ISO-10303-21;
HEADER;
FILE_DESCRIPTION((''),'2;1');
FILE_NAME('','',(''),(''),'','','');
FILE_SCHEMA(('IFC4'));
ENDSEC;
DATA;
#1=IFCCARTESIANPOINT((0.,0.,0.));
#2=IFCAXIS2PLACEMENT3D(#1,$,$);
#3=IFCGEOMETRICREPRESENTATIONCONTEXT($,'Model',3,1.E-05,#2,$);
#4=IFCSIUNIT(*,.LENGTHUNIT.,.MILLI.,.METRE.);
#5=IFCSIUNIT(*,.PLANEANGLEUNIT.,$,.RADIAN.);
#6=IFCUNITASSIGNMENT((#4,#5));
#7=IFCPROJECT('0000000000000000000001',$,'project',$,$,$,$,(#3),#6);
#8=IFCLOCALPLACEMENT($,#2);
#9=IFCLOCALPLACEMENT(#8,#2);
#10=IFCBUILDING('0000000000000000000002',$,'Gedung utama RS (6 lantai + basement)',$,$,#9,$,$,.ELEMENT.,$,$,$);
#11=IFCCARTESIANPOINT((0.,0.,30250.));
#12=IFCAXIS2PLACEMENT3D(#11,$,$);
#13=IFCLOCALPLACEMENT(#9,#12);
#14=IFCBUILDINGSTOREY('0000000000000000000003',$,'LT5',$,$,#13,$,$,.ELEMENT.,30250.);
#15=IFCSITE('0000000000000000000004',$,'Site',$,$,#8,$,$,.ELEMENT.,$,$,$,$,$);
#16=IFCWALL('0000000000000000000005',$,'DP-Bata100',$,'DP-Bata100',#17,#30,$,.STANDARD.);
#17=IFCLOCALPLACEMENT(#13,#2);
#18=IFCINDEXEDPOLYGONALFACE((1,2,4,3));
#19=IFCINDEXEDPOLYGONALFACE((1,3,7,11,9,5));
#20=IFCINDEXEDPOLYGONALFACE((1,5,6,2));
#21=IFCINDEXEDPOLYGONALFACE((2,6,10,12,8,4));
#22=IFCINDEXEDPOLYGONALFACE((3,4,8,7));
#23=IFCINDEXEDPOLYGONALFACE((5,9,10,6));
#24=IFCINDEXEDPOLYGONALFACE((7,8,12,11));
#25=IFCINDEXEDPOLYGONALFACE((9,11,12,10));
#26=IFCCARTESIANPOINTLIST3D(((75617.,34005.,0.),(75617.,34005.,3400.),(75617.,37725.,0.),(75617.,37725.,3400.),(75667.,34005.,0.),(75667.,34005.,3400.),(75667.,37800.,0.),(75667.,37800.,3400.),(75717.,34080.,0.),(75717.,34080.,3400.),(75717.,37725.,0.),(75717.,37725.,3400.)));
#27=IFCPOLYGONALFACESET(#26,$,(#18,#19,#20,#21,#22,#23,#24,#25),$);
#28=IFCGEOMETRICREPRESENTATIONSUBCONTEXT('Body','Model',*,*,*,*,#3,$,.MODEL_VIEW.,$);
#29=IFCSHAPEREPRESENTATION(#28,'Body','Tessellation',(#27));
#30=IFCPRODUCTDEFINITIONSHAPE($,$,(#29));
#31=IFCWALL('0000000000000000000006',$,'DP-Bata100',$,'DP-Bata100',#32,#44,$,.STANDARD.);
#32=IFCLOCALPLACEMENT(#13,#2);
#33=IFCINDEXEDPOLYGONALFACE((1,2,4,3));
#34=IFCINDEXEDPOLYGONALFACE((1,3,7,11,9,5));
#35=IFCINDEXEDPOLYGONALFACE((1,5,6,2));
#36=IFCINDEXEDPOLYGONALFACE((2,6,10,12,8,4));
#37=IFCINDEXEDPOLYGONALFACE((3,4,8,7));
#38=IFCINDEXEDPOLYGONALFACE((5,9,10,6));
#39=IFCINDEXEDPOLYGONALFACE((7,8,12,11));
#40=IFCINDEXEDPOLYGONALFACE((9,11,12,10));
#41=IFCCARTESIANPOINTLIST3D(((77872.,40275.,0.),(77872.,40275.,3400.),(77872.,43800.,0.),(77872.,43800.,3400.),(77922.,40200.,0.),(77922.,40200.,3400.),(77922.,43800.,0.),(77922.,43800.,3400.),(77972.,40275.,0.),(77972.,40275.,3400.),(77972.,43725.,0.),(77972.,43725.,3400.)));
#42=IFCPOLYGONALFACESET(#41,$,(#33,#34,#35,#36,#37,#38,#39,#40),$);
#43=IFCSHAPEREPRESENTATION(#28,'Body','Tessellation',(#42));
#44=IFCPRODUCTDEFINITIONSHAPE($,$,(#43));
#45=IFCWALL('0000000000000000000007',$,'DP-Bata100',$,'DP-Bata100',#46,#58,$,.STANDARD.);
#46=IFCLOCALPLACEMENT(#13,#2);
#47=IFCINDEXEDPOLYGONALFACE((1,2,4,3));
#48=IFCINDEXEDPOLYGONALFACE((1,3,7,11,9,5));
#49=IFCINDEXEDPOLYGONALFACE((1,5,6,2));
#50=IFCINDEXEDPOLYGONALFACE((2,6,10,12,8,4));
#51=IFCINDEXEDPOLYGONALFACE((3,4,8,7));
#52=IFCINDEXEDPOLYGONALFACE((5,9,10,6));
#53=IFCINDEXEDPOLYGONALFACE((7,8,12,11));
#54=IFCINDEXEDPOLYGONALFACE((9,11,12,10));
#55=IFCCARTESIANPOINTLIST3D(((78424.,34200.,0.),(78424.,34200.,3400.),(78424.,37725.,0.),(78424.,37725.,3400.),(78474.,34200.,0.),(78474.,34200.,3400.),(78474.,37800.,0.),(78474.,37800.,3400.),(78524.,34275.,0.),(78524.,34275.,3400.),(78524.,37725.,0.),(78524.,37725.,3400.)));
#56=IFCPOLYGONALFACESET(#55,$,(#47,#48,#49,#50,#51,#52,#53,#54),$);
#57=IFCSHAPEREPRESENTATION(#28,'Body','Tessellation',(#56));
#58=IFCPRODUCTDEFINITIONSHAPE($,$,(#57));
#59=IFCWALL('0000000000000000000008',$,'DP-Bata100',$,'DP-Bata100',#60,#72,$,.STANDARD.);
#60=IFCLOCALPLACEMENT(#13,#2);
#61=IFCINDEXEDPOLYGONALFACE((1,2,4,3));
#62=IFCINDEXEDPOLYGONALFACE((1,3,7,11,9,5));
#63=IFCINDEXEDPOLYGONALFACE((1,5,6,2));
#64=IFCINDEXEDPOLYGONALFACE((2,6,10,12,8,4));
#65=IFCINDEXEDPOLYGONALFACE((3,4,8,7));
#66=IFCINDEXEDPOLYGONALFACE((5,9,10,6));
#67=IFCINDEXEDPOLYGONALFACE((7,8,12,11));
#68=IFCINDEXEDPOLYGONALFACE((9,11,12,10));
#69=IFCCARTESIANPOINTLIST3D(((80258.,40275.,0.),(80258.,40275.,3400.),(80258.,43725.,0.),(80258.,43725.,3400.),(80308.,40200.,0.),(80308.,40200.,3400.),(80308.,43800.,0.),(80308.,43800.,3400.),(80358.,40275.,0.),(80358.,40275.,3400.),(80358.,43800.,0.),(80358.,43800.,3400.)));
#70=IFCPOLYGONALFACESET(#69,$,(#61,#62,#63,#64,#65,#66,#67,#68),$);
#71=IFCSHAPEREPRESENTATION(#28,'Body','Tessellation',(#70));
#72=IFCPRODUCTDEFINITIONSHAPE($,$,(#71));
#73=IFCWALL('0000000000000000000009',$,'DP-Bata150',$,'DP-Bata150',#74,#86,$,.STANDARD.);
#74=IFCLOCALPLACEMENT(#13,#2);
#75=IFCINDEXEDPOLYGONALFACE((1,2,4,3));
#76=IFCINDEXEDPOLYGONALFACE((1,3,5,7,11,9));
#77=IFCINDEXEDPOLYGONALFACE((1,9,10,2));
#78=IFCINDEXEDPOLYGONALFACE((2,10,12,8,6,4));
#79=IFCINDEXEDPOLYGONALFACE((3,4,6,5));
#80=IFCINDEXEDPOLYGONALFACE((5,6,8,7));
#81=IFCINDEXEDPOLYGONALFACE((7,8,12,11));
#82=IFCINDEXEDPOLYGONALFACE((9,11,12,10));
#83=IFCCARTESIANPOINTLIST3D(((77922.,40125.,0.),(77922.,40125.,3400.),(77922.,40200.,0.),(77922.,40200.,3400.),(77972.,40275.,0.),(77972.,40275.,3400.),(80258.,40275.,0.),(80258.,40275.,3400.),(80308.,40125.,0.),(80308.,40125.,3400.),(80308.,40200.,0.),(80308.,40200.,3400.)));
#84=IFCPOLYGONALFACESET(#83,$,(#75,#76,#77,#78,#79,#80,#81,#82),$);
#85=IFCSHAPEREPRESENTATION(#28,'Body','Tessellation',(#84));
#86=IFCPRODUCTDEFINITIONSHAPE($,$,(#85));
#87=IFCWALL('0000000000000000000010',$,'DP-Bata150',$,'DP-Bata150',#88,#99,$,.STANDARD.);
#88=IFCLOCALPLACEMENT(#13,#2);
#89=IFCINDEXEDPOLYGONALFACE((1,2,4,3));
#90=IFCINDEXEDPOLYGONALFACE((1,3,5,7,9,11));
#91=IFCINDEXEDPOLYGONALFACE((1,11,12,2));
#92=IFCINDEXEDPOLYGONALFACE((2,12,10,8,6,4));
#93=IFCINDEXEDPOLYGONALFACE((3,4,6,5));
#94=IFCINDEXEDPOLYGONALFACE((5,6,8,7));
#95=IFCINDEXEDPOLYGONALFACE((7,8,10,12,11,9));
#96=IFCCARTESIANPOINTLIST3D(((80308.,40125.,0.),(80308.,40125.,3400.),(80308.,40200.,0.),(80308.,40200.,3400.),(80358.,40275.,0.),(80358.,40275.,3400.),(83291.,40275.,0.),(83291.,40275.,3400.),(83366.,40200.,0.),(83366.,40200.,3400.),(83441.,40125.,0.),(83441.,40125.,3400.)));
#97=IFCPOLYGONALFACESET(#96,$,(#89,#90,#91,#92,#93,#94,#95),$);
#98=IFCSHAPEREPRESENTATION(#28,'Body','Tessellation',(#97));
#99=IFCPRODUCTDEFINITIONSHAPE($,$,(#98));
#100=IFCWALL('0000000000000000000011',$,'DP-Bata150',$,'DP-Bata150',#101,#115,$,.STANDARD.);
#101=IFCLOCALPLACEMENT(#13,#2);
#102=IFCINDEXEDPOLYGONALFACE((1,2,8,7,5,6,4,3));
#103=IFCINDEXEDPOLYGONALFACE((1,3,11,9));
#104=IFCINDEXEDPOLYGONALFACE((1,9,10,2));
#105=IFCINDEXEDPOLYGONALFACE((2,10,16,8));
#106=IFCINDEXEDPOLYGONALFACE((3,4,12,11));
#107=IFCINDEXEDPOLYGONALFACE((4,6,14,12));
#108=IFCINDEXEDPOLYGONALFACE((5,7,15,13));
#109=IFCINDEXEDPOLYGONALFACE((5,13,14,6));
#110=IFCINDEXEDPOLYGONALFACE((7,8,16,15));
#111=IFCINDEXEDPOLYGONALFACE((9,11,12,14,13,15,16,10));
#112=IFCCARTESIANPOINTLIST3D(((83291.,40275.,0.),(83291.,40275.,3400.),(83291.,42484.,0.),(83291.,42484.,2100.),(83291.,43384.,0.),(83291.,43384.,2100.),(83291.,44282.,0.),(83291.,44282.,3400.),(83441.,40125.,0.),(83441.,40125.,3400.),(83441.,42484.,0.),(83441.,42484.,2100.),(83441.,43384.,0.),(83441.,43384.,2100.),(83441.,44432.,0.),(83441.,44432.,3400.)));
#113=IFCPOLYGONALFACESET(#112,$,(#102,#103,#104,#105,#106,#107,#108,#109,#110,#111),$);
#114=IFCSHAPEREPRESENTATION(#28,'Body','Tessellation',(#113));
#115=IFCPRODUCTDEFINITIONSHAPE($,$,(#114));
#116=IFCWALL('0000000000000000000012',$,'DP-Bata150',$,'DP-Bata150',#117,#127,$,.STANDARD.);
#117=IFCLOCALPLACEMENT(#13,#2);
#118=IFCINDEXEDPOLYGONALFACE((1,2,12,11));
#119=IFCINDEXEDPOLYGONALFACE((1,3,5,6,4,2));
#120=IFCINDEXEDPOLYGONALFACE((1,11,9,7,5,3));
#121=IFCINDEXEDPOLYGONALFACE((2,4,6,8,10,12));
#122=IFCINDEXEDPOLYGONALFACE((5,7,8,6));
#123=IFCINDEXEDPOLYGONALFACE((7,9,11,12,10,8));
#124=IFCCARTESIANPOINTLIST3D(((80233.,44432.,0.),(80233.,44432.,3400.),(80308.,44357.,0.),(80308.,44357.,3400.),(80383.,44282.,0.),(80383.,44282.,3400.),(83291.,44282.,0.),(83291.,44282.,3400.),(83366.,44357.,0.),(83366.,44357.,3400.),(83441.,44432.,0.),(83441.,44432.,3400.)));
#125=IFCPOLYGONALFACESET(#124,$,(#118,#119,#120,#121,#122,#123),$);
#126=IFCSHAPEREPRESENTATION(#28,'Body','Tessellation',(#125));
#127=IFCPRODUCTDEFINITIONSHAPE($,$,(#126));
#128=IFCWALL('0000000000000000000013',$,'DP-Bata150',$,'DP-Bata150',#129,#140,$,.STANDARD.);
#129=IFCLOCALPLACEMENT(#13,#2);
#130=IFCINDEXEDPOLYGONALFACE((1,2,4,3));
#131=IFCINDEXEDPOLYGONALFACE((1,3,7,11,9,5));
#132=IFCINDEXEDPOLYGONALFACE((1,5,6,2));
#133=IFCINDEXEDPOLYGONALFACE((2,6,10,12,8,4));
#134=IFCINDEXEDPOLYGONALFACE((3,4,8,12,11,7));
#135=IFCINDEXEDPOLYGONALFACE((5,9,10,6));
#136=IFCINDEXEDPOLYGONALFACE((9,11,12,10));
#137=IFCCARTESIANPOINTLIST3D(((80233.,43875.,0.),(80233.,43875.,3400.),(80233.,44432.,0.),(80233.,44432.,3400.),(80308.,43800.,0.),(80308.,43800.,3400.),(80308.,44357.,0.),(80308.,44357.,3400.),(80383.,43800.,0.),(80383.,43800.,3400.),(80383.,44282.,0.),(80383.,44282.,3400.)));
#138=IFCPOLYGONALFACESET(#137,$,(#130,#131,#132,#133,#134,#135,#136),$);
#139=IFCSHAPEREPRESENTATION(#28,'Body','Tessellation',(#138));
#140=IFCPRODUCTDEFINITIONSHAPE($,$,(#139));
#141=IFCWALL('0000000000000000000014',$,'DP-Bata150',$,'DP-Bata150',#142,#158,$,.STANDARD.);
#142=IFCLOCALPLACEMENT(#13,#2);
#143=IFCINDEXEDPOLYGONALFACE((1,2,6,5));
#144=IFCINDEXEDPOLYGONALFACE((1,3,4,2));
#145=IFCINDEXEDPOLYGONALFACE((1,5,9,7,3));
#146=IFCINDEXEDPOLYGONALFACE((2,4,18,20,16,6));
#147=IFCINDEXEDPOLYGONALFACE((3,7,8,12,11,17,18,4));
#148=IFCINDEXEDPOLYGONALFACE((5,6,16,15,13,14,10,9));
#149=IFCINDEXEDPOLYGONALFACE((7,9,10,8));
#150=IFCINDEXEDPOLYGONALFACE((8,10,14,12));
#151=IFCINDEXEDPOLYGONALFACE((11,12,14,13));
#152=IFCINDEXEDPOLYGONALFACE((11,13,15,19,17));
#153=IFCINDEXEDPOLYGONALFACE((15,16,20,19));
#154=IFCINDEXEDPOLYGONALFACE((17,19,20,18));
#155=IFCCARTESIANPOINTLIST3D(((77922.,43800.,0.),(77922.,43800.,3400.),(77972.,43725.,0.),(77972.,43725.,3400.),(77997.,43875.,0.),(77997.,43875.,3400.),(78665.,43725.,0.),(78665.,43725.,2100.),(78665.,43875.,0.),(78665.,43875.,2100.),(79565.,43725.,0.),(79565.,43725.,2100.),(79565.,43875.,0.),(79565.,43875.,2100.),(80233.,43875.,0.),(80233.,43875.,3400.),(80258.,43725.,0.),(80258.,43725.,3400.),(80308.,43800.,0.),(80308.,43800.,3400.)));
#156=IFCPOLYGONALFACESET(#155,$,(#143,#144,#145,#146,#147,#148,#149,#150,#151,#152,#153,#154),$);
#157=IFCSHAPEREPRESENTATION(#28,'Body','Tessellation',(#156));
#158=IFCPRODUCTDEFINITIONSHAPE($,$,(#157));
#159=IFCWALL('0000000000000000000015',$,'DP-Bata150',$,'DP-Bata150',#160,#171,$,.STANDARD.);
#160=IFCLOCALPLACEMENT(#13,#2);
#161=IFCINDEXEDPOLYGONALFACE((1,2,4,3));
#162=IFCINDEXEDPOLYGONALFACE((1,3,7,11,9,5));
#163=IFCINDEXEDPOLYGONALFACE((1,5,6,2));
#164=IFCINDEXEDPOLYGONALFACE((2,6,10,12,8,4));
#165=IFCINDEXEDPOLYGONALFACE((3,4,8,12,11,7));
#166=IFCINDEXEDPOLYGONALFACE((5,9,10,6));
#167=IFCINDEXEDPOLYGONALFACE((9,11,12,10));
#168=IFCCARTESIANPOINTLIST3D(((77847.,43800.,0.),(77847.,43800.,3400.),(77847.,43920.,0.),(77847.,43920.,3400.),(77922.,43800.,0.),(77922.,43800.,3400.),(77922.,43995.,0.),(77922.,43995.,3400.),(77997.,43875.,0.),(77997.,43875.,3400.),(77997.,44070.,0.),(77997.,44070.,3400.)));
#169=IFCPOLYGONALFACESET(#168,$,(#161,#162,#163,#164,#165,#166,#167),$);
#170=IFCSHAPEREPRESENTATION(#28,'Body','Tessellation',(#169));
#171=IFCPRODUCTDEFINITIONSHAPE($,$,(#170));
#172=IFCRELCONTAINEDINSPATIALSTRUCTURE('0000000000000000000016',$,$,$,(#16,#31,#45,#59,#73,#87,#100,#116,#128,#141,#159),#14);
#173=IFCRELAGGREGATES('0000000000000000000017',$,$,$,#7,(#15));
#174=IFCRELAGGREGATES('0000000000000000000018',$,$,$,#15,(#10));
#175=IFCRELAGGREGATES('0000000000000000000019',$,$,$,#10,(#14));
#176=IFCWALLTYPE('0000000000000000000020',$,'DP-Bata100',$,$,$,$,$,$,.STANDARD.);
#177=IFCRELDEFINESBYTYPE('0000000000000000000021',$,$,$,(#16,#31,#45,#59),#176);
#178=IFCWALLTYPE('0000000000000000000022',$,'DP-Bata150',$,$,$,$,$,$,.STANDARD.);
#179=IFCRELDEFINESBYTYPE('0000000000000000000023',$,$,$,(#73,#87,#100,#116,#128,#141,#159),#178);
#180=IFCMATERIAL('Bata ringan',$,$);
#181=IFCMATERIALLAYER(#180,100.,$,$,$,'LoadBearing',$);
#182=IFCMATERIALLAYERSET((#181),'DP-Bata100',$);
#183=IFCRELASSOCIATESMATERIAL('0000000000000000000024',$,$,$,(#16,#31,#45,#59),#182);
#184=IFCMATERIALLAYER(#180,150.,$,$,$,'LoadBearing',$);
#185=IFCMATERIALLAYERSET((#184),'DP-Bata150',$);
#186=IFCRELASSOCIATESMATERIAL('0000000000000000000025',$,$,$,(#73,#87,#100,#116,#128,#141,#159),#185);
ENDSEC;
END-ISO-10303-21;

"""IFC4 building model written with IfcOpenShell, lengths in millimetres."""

from ifc_helpers import new_model, si_unit, frame, frame_2d, origin, place, context, subcontext, project, spatial, polyline, rectangle, outline, extrude, material, layer, layer_set, layer_usage, type_object, element, save


model = new_model("IFC4")

# Units and contexts
model_context = context("Model", 3, precision=1e-05, world=origin())
body_context = subcontext(model_context, "Body", "Model", "MODEL_VIEW")
ifc_project = project(units=[si_unit("LENGTHUNIT", "METRE", prefix="MILLI"), si_unit("PLANEANGLEUNIT", "RADIAN")], contexts=[model_context])

# Site, building, storey
site_placement = place(None, origin())
site = spatial("IfcSite", under=ifc_project, at=site_placement, Name="Site", CompositionType="ELEMENT")
building_placement = place(site_placement, origin())
building = spatial("IfcBuilding", under=site, at=building_placement, Name="Gedung utama RS (6 lantai + basement)", CompositionType="ELEMENT")
storey_placement = place(building_placement, frame((0.0, 0.0, 30250.0)))
storey = spatial("IfcBuildingStorey", under=building, at=storey_placement, Name="LT5", CompositionType="ELEMENT", Elevation=30250.0)

# Walls
ifc_material_1 = material(Name="Bata ringan")
ifc_layer_1 = layer(ifc_material_1, 100.0, Category="LoadBearing")
ifc_layer_set_1 = layer_set([ifc_layer_1], Name="DP-Bata100")
ifc_layer_usage_1 = layer_usage(ifc_layer_set_1, "AXIS2", "NEGATIVE", 50.0)
wall_type_1 = type_object("IfcWallType", Name="DP-Bata100", PredefinedType="STANDARD")
wall_1_placement = place(storey_placement, frame((75667.0, 37800.0, 0.0), z_axis=(0.0, 0.0, 1.0), x_axis=(0.0, -1.0, 0.0)))
element("IfcWall", 1, at=wall_1_placement, inside=storey, type_object=wall_type_1, material=ifc_layer_usage_1, Name="DP-Bata100", ObjectType="DP-Bata100", PredefinedType="STANDARD", context=body_context, shape_type="SweptSolid", body=[
    extrude(outline(polyline([(75.0, -50.0), (0.0, 0.0), (75.0, 50.0), (3720.0, 50.0), (3795.0, 0.0), (3795.0, -50.0), (75.0, -50.0)])), origin(), (0.0, 0.0, 1.0), 3400.0),
])
wall_2_placement = place(storey_placement, frame((77922.0, 40200.0, 0.0), z_axis=(0.0, 0.0, 1.0), x_axis=(0.0, 1.0, 0.0)))
element("IfcWall", 2, at=wall_2_placement, inside=storey, type_object=wall_type_1, material=ifc_layer_usage_1, Name="DP-Bata100", ObjectType="DP-Bata100", PredefinedType="STANDARD", context=body_context, shape_type="SweptSolid", body=[
    extrude(outline(polyline([(75.0, -50.0), (0.0, 0.0), (75.0, 50.0), (3600.0, 50.0), (3600.0, 0.0), (3525.0, -50.0), (75.0, -50.0)])), origin(), (0.0, 0.0, 1.0), 3400.0),
])
wall_3_placement = place(storey_placement, frame((78474.0, 34200.0, 0.0), z_axis=(0.0, 0.0, 1.0), x_axis=(0.0, 1.0, 0.0)))
element("IfcWall", 3, at=wall_3_placement, inside=storey, type_object=wall_type_1, material=ifc_layer_usage_1, Name="DP-Bata100", ObjectType="DP-Bata100", PredefinedType="STANDARD", context=body_context, shape_type="SweptSolid", body=[
    extrude(outline(polyline([(75.0, -50.0), (0.0, 0.0), (0.0, 50.0), (3525.0, 50.0), (3600.0, 0.0), (3525.0, -50.0), (75.0, -50.0)])), origin(), (0.0, 0.0, 1.0), 3400.0),
])
wall_4_placement = place(storey_placement, frame((80308.0, 40200.0, 0.0), z_axis=(0.0, 0.0, 1.0), x_axis=(0.0, 1.0, 0.0)))
element("IfcWall", 4, at=wall_4_placement, inside=storey, type_object=wall_type_1, material=ifc_layer_usage_1, Name="DP-Bata100", ObjectType="DP-Bata100", PredefinedType="STANDARD", context=body_context, shape_type="SweptSolid", body=[
    extrude(outline(polyline([(75.0, -50.0), (0.0, 0.0), (75.0, 50.0), (3525.0, 50.0), (3600.0, 0.0), (3600.0, -50.0), (75.0, -50.0)])), origin(), (0.0, 0.0, 1.0), 3400.0),
])
ifc_layer_2 = layer(ifc_material_1, 150.0, Category="LoadBearing")
ifc_layer_set_2 = layer_set([ifc_layer_2], Name="DP-Bata150")
ifc_layer_usage_2 = layer_usage(ifc_layer_set_2, "AXIS2", "NEGATIVE", 75.0)
wall_type_2 = type_object("IfcWallType", Name="DP-Bata150", PredefinedType="STANDARD")
wall_5_placement = place(storey_placement, frame((77922.0, 40200.0, 0.0), z_axis=(0.0, 0.0, 1.0), x_axis=(1.0, 0.0, 0.0)))
element("IfcWall", 5, at=wall_5_placement, inside=storey, type_object=wall_type_2, material=ifc_layer_usage_2, Name="DP-Bata150", ObjectType="DP-Bata150", PredefinedType="STANDARD", context=body_context, shape_type="SweptSolid", body=[
    extrude(outline(polyline([(0.0, -75.0), (0.0, 0.0), (50.0, 75.0), (2336.0, 75.0), (2386.0, 0.0), (2386.0, -75.0), (0.0, -75.0)])), origin(), (0.0, 0.0, 1.0), 3400.0),
])
wall_6_placement = place(storey_placement, frame((80308.0, 40200.0, 0.0), z_axis=(0.0, 0.0, 1.0), x_axis=(1.0, 0.0, 0.0)))
element("IfcWall", 6, at=wall_6_placement, inside=storey, type_object=wall_type_2, material=ifc_layer_usage_2, Name="DP-Bata150", ObjectType="DP-Bata150", PredefinedType="STANDARD", context=body_context, shape_type="SweptSolid", body=[
    extrude(outline(polyline([(0.0, -75.0), (0.0, 0.0), (50.0, 75.0), (2983.0, 75.0), (3058.0, 0.0), (3133.0, -75.0), (0.0, -75.0)])), origin(), (0.0, 0.0, 1.0), 3400.0),
])

# Wall, opening
wall_7_placement = place(storey_placement, frame((83366.0, 40200.0, 0.0), z_axis=(0.0, 0.0, 1.0), x_axis=(0.0, 1.0, 0.0)))
wall_7 = element("IfcWall", 7, at=wall_7_placement, inside=storey, type_object=wall_type_2, material=ifc_layer_usage_2, Name="DP-Bata150", ObjectType="DP-Bata150", PredefinedType="STANDARD", context=body_context, shape_type="SweptSolid", body=[
    extrude(outline(polyline([(-75.0, -75.0), (0.0, 0.0), (75.0, 75.0), (4082.0, 75.0), (4157.0, 0.0), (4232.0, -75.0), (-75.0, -75.0)])), origin(), (0.0, 0.0, 1.0), 3400.0),
])
opening_1_placement = place(wall_7_placement, frame((2284.0, 0.0, 0.0), z_axis=(0.0, 0.0, 1.0), x_axis=(1.0, 0.0, 0.0)))
element("IfcOpeningElement", 8, at=opening_1_placement, cuts=wall_7, PredefinedType="OPENING", context=body_context, shape_type="SweptSolid", body=[
    extrude(rectangle(XDim=900.0, YDim=170.0, at=frame_2d((450.0, 0.0))), origin(), (0.0, 0.0, 1.0), 2100.0),
])

# Walls
wall_8_placement = place(storey_placement, frame((83366.0, 44357.0, 0.0), z_axis=(0.0, 0.0, 1.0), x_axis=(-1.0, 0.0, 0.0)))
element("IfcWall", 9, at=wall_8_placement, inside=storey, type_object=wall_type_2, material=ifc_layer_usage_2, Name="DP-Bata150", ObjectType="DP-Bata150", PredefinedType="STANDARD", context=body_context, shape_type="SweptSolid", body=[
    extrude(outline(polyline([(-75.0, -75.0), (0.0, 0.0), (75.0, 75.0), (2983.0, 75.0), (3058.0, 0.0), (3133.0, -75.0), (-75.0, -75.0)])), origin(), (0.0, 0.0, 1.0), 3400.0),
])
wall_9_placement = place(storey_placement, frame((80308.0, 44357.0, 0.0), z_axis=(0.0, 0.0, 1.0), x_axis=(0.0, -1.0, 0.0)))
element("IfcWall", 10, at=wall_9_placement, inside=storey, type_object=wall_type_2, material=ifc_layer_usage_2, Name="DP-Bata150", ObjectType="DP-Bata150", PredefinedType="STANDARD", context=body_context, shape_type="SweptSolid", body=[
    extrude(outline(polyline([(-75.0, -75.0), (0.0, 0.0), (75.0, 75.0), (557.0, 75.0), (557.0, 0.0), (482.0, -75.0), (-75.0, -75.0)])), origin(), (0.0, 0.0, 1.0), 3400.0),
])

# Wall, opening
wall_10_placement = place(storey_placement, frame((80308.0, 43800.0, 0.0), z_axis=(0.0, 0.0, 1.0), x_axis=(-1.0, 0.0, 0.0)))
wall_10 = element("IfcWall", 11, at=wall_10_placement, inside=storey, type_object=wall_type_2, material=ifc_layer_usage_2, Name="DP-Bata150", ObjectType="DP-Bata150", PredefinedType="STANDARD", context=body_context, shape_type="SweptSolid", body=[
    extrude(outline(polyline([(75.0, -75.0), (0.0, 0.0), (50.0, 75.0), (2336.0, 75.0), (2386.0, 0.0), (2311.0, -75.0), (75.0, -75.0)])), origin(), (0.0, 0.0, 1.0), 3400.0),
])
opening_2_placement = place(wall_10_placement, frame((743.0, 0.0, 0.0), z_axis=(0.0, 0.0, 1.0), x_axis=(1.0, 0.0, 0.0)))
element("IfcOpeningElement", 12, at=opening_2_placement, cuts=wall_10, PredefinedType="OPENING", context=body_context, shape_type="SweptSolid", body=[
    extrude(rectangle(XDim=900.0, YDim=170.0, at=frame_2d((450.0, 0.0))), origin(), (0.0, 0.0, 1.0), 2100.0),
])

# Wall
wall_11_placement = place(storey_placement, frame((77922.0, 43800.0, 0.0), z_axis=(0.0, 0.0, 1.0), x_axis=(0.0, 1.0, 0.0)))
element("IfcWall", 13, at=wall_11_placement, inside=storey, type_object=wall_type_2, material=ifc_layer_usage_2, Name="DP-Bata150", ObjectType="DP-Bata150", PredefinedType="STANDARD", context=body_context, shape_type="SweptSolid", body=[
    extrude(outline(polyline([(75.0, -75.0), (0.0, 0.0), (0.0, 75.0), (120.0, 75.0), (195.0, 0.0), (270.0, -75.0), (75.0, -75.0)])), origin(), (0.0, 0.0, 1.0), 3400.0),
])

save(model, "model.ifc")
